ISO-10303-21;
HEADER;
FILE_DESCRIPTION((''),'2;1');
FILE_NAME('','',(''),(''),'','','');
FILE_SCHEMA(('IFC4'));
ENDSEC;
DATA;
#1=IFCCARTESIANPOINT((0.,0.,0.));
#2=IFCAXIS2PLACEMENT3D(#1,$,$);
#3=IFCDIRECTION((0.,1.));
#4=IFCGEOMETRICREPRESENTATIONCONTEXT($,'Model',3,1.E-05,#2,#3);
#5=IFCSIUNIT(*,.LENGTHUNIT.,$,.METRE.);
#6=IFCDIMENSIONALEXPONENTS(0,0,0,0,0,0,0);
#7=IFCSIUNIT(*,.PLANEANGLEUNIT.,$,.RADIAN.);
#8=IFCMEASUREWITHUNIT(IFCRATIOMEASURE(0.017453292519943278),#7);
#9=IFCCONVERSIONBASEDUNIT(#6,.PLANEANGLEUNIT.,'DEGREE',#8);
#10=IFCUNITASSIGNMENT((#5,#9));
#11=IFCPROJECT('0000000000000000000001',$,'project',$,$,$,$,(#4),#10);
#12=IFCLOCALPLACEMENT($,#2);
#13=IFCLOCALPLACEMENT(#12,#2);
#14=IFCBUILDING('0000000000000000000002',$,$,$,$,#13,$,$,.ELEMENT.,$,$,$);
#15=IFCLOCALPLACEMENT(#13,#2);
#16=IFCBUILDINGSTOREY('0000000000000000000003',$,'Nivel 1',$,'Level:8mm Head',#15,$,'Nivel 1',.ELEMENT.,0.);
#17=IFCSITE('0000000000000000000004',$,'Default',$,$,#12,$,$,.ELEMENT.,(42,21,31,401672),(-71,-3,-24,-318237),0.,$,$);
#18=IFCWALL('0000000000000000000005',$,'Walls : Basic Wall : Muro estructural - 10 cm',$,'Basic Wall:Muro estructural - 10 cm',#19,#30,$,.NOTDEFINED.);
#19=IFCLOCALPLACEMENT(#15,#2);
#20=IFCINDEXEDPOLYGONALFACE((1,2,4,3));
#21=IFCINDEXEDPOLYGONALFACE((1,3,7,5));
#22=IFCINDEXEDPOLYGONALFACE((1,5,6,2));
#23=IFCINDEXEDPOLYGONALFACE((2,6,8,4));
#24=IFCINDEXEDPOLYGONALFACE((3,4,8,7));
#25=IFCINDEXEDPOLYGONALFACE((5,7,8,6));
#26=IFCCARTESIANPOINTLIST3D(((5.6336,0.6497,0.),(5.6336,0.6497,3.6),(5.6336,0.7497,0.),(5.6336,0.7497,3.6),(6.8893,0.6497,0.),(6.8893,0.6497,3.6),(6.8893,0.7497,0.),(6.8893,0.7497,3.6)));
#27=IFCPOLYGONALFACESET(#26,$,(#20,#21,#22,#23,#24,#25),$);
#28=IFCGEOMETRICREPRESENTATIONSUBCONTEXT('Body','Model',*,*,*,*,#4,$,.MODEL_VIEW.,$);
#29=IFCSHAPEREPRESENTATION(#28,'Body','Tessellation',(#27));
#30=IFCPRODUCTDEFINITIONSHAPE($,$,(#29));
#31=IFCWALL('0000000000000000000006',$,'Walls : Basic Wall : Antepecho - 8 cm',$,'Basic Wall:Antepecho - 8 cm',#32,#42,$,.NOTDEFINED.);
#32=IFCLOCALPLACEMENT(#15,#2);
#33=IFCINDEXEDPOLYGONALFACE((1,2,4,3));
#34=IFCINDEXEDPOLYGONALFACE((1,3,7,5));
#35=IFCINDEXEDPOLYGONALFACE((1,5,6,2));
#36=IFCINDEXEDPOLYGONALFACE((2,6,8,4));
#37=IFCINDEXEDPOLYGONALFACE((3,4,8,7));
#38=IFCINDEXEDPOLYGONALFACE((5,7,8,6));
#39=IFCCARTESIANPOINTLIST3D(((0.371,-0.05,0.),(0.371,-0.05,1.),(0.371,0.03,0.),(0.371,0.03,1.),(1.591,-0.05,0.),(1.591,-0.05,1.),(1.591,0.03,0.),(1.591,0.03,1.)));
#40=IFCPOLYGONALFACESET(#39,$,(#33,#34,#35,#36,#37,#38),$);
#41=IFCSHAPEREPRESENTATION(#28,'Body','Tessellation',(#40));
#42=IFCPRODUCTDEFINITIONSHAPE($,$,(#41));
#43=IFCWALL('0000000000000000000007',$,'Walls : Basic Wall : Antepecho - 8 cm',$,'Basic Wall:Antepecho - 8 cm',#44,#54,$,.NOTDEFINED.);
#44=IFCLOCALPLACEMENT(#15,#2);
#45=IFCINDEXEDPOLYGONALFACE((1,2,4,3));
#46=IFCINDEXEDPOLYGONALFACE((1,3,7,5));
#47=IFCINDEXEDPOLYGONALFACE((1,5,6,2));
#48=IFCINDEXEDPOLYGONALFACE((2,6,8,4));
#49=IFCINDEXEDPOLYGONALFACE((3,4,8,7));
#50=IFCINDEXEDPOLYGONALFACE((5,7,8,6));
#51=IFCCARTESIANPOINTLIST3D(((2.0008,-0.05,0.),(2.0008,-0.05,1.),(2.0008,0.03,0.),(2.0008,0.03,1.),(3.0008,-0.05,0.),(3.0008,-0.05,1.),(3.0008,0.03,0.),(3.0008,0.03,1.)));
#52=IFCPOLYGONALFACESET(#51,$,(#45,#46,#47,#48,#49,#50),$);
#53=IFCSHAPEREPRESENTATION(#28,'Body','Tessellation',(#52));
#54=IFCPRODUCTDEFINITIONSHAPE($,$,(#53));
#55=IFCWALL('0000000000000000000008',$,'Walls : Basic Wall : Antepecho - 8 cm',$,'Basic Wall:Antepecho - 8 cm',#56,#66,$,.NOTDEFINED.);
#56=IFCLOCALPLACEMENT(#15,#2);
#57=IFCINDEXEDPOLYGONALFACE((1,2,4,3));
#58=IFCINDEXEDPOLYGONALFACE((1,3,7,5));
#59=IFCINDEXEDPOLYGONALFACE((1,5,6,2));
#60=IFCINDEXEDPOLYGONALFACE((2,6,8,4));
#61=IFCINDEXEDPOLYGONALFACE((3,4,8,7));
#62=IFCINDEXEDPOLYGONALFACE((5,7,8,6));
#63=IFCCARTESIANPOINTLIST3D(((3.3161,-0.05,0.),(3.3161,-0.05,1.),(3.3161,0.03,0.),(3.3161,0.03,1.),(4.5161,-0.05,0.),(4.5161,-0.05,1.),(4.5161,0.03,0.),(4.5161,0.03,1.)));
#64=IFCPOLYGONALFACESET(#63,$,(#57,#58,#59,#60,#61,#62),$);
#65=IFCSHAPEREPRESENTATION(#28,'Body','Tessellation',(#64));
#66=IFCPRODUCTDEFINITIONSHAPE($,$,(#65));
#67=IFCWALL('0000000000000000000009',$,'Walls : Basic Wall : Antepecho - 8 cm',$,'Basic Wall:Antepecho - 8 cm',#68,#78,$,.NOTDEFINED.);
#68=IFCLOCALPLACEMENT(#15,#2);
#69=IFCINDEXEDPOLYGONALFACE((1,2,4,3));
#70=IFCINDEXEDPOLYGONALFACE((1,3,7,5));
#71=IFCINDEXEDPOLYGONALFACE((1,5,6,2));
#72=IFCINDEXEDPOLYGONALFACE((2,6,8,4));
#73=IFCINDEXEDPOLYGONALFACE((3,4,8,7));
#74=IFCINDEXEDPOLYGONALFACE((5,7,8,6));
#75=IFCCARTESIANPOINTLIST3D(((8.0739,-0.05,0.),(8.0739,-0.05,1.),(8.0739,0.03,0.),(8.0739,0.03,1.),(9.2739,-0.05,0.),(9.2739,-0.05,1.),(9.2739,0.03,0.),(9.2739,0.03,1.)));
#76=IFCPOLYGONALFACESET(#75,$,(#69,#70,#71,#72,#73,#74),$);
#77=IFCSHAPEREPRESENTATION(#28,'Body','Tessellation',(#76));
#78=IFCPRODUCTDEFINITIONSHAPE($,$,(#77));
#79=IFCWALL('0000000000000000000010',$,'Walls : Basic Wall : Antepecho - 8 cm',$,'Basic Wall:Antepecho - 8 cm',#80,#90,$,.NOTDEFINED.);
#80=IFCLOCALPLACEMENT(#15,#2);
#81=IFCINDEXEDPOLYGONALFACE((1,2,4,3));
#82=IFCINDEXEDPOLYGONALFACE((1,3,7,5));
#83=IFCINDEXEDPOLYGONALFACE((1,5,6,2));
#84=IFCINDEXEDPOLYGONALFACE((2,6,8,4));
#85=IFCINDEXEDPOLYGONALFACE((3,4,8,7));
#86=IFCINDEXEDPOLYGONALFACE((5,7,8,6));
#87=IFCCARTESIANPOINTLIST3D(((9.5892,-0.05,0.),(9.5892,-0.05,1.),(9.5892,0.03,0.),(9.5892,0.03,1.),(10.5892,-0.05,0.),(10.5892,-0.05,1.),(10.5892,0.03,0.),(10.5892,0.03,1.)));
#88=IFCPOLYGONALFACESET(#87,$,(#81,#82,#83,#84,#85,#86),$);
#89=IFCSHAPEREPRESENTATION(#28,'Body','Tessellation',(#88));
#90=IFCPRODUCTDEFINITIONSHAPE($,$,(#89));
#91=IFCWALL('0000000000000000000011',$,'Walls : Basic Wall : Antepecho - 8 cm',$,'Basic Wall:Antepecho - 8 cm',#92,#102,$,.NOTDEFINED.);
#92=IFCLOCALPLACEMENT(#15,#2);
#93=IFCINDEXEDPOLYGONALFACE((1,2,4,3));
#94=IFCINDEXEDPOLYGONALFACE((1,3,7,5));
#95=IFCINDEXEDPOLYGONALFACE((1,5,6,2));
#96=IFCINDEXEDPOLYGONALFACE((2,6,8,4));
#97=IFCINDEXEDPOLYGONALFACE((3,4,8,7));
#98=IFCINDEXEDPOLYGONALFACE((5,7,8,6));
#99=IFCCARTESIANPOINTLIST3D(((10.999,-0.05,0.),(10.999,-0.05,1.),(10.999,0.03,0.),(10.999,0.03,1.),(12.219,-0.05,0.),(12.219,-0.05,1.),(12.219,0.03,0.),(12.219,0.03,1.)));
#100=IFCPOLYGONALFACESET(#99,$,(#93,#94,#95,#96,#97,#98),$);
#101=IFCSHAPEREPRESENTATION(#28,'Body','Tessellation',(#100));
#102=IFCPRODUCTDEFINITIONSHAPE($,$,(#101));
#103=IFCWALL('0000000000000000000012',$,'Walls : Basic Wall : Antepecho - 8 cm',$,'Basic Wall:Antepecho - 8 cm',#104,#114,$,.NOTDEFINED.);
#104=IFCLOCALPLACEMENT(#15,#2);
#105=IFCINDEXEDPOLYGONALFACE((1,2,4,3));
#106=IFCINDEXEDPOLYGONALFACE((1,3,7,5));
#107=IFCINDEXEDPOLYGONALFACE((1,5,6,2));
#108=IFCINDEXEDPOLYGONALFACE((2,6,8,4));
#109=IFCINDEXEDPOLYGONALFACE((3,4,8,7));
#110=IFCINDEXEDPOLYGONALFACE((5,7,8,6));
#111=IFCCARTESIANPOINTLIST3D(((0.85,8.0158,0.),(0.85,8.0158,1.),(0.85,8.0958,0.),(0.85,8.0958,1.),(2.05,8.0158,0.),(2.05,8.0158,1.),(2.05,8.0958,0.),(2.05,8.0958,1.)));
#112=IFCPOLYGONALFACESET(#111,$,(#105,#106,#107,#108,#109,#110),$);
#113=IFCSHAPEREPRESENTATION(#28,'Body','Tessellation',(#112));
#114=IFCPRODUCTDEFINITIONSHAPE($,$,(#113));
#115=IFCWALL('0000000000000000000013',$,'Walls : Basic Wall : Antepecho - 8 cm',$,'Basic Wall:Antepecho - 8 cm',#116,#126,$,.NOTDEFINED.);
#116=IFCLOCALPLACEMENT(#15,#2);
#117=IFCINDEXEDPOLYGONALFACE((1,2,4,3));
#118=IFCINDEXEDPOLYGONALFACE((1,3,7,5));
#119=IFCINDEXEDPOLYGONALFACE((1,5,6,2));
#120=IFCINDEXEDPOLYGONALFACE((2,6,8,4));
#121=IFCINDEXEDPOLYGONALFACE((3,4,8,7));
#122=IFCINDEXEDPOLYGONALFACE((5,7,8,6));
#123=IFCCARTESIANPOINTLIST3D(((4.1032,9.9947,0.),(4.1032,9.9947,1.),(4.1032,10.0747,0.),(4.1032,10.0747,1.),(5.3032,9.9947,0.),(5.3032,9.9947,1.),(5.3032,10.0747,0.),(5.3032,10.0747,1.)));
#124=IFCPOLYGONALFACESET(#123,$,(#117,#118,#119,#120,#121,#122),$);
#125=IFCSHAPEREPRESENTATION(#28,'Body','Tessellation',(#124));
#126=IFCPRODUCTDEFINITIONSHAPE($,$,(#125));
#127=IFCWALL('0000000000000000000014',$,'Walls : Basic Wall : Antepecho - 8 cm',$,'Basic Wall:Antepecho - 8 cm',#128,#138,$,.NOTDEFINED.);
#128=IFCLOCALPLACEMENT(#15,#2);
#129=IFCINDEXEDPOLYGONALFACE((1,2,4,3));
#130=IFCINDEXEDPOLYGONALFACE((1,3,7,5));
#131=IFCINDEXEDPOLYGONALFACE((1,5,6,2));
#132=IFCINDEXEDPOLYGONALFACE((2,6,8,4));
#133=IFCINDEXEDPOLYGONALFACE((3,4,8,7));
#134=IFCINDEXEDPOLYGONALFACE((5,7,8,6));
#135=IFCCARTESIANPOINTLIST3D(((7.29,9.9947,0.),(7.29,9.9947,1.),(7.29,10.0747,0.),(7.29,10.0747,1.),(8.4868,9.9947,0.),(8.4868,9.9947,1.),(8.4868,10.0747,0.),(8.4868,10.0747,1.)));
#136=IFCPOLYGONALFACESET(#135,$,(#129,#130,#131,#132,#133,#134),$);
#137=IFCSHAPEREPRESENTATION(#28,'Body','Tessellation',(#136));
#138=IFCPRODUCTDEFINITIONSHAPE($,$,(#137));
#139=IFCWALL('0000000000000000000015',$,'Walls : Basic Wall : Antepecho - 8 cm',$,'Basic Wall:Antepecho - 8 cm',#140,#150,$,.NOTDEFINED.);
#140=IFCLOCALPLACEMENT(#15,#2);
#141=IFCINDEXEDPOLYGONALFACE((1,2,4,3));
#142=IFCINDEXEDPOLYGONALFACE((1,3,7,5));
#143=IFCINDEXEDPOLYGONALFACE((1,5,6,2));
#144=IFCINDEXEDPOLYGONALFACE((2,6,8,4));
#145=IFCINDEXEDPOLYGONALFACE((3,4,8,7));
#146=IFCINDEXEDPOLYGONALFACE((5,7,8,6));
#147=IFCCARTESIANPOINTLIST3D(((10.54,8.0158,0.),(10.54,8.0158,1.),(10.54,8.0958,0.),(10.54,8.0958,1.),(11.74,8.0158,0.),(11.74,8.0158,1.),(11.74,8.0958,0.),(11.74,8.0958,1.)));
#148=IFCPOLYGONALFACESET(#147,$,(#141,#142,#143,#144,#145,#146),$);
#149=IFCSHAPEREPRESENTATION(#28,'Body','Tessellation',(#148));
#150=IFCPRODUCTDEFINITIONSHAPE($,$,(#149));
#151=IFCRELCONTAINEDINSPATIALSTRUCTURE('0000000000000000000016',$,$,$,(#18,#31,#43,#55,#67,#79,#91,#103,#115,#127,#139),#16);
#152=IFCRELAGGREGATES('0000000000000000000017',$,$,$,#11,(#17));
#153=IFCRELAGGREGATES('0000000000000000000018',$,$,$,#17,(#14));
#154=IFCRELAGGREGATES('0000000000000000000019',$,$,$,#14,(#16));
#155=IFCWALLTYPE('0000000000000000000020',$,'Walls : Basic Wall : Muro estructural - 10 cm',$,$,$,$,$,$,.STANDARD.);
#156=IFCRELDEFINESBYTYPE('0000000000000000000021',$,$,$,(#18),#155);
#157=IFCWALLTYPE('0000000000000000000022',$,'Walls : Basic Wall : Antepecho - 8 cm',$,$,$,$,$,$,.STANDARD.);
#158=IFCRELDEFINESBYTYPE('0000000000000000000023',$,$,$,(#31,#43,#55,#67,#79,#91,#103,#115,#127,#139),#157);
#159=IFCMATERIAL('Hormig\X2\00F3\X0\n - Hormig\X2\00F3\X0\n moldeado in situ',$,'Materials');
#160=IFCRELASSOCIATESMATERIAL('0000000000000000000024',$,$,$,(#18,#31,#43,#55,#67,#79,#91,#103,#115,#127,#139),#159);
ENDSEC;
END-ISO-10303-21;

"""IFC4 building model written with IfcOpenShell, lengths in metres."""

from ifc_helpers import new_model, entity, si_unit, converted_unit, direction, frame, origin, place, context, subcontext, project, spatial, indexed_curve, outline, extrude, material, type_object, element, save


model = new_model("IFC4")

# Units and contexts
model_context = context("Model", 3, precision=1e-05, world=origin(), true_north=direction((0.0, 1.0)))
body_context = subcontext(model_context, "Body", "Model", "MODEL_VIEW")
ifc_project = project(units=[si_unit("LENGTHUNIT", "METRE"), converted_unit("PLANEANGLEUNIT", "DEGREE", entity("IfcRatioMeasure", 0.017453292519943278), si_unit("PLANEANGLEUNIT", "RADIAN"), dimensions=[0, 0, 0, 0, 0, 0, 0])], contexts=[model_context])

# Site, building, storey
site_placement = place(None, origin())
site = spatial("IfcSite", under=ifc_project, at=site_placement, Name="Default", CompositionType="ELEMENT", RefLatitude=(42, 21, 31, 401672), RefLongitude=(-71, -3, -24, -318237), RefElevation=0.0)
building_placement = place(site_placement, origin())
building = spatial("IfcBuilding", under=site, at=building_placement, CompositionType="ELEMENT")
storey_placement = place(building_placement, origin())
storey = spatial("IfcBuildingStorey", under=building, at=storey_placement, Name="Nivel 1", ObjectType="Level:8mm Head", LongName="Nivel 1", CompositionType="ELEMENT", Elevation=0.0)

# Walls
ifc_material_1 = material(Name="Hormigón - Hormigón moldeado in situ", Category="Materials")
wall_type_1 = type_object("IfcWallType", Name="Walls : Basic Wall : Muro estructural - 10 cm", PredefinedType="STANDARD")
wall_1_placement = place(storey_placement, frame((5.6336, 0.6997, 0.0)))
element("IfcWall", 1, at=wall_1_placement, inside=storey, type_object=wall_type_1, material=ifc_material_1, Name="Walls : Basic Wall : Muro estructural - 10 cm", ObjectType="Basic Wall:Muro estructural - 10 cm", PredefinedType="NOTDEFINED", context=body_context, shape_type="SweptSolid", body=[
    extrude(outline(indexed_curve([(1.2557, 0.05), (0.0, 0.05), (0.0, -0.05), (1.2557, -0.05), (1.2557, 0.05)], self_intersect=False)), origin(), (0.0, 0.0, 1.0), 3.6),
])
wall_type_2 = type_object("IfcWallType", Name="Walls : Basic Wall : Antepecho - 8 cm", PredefinedType="STANDARD")
wall_2_placement = place(storey_placement, frame((0.371, -0.01, 0.0)))
element("IfcWall", 2, at=wall_2_placement, inside=storey, type_object=wall_type_2, material=ifc_material_1, Name="Walls : Basic Wall : Antepecho - 8 cm", ObjectType="Basic Wall:Antepecho - 8 cm", PredefinedType="NOTDEFINED", context=body_context, shape_type="SweptSolid", body=[
    extrude(outline(indexed_curve([(1.22, 0.04), (0.0, 0.04), (0.0, -0.04), (1.22, -0.04), (1.22, 0.04)], self_intersect=False)), origin(), (0.0, 0.0, 1.0), 1.0),
])
wall_3_placement = place(storey_placement, frame((2.0008, -0.01, 0.0)))
element("IfcWall", 3, at=wall_3_placement, inside=storey, type_object=wall_type_2, material=ifc_material_1, Name="Walls : Basic Wall : Antepecho - 8 cm", ObjectType="Basic Wall:Antepecho - 8 cm", PredefinedType="NOTDEFINED", context=body_context, shape_type="SweptSolid", body=[
    extrude(outline(indexed_curve([(1.0, 0.04), (0.0, 0.04), (0.0, -0.04), (1.0, -0.04), (1.0, 0.04)], self_intersect=False)), origin(), (0.0, 0.0, 1.0), 1.0),
])
wall_4_placement = place(storey_placement, frame((3.3161, -0.01, 0.0)))
element("IfcWall", 4, at=wall_4_placement, inside=storey, type_object=wall_type_2, material=ifc_material_1, Name="Walls : Basic Wall : Antepecho - 8 cm", ObjectType="Basic Wall:Antepecho - 8 cm", PredefinedType="NOTDEFINED", context=body_context, shape_type="SweptSolid", body=[
    extrude(outline(indexed_curve([(1.2, 0.04), (0.0, 0.04), (0.0, -0.04), (1.2, -0.04), (1.2, 0.04)], self_intersect=False)), origin(), (0.0, 0.0, 1.0), 1.0),
])
wall_5_placement = place(storey_placement, frame((8.0739, -0.01, 0.0)))
element("IfcWall", 5, at=wall_5_placement, inside=storey, type_object=wall_type_2, material=ifc_material_1, Name="Walls : Basic Wall : Antepecho - 8 cm", ObjectType="Basic Wall:Antepecho - 8 cm", PredefinedType="NOTDEFINED", context=body_context, shape_type="SweptSolid", body=[
    extrude(outline(indexed_curve([(1.2, 0.04), (0.0, 0.04), (0.0, -0.04), (1.2, -0.04), (1.2, 0.04)], self_intersect=False)), origin(), (0.0, 0.0, 1.0), 1.0),
])
wall_6_placement = place(storey_placement, frame((9.5892, -0.01, 0.0)))
element("IfcWall", 6, at=wall_6_placement, inside=storey, type_object=wall_type_2, material=ifc_material_1, Name="Walls : Basic Wall : Antepecho - 8 cm", ObjectType="Basic Wall:Antepecho - 8 cm", PredefinedType="NOTDEFINED", context=body_context, shape_type="SweptSolid", body=[
    extrude(outline(indexed_curve([(1.0, 0.04), (0.0, 0.04), (0.0, -0.04), (1.0, -0.04), (1.0, 0.04)], self_intersect=False)), origin(), (0.0, 0.0, 1.0), 1.0),
])
wall_7_placement = place(storey_placement, frame((10.999, -0.01, 0.0)))
element("IfcWall", 7, at=wall_7_placement, inside=storey, type_object=wall_type_2, material=ifc_material_1, Name="Walls : Basic Wall : Antepecho - 8 cm", ObjectType="Basic Wall:Antepecho - 8 cm", PredefinedType="NOTDEFINED", context=body_context, shape_type="SweptSolid", body=[
    extrude(outline(indexed_curve([(1.22, 0.04), (0.0, 0.04), (0.0, -0.04), (1.22, -0.04), (1.22, 0.04)], self_intersect=False)), origin(), (0.0, 0.0, 1.0), 1.0),
])
wall_8_placement = place(storey_placement, frame((2.05, 8.0558, 0.0), z_axis=(0.0, 0.0, 1.0), x_axis=(-1.0, 0.0, 0.0)))
element("IfcWall", 8, at=wall_8_placement, inside=storey, type_object=wall_type_2, material=ifc_material_1, Name="Walls : Basic Wall : Antepecho - 8 cm", ObjectType="Basic Wall:Antepecho - 8 cm", PredefinedType="NOTDEFINED", context=body_context, shape_type="SweptSolid", body=[
    extrude(outline(indexed_curve([(1.2, 0.04), (0.0, 0.04), (0.0, -0.04), (1.2, -0.04), (1.2, 0.04)], self_intersect=False)), origin(), (0.0, 0.0, 1.0), 1.0),
])
wall_9_placement = place(storey_placement, frame((5.3032, 10.0347, 0.0), z_axis=(0.0, 0.0, 1.0), x_axis=(-1.0, 0.0, 0.0)))
element("IfcWall", 9, at=wall_9_placement, inside=storey, type_object=wall_type_2, material=ifc_material_1, Name="Walls : Basic Wall : Antepecho - 8 cm", ObjectType="Basic Wall:Antepecho - 8 cm", PredefinedType="NOTDEFINED", context=body_context, shape_type="SweptSolid", body=[
    extrude(outline(indexed_curve([(1.2, 0.04), (0.0, 0.04), (0.0, -0.04), (1.2, -0.04), (1.2, 0.04)], self_intersect=False)), origin(), (0.0, 0.0, 1.0), 1.0),
])
wall_10_placement = place(storey_placement, frame((8.4868, 10.0347, 0.0), z_axis=(0.0, 0.0, 1.0), x_axis=(-1.0, 0.0, 0.0)))
element("IfcWall", 10, at=wall_10_placement, inside=storey, type_object=wall_type_2, material=ifc_material_1, Name="Walls : Basic Wall : Antepecho - 8 cm", ObjectType="Basic Wall:Antepecho - 8 cm", PredefinedType="NOTDEFINED", context=body_context, shape_type="SweptSolid", body=[
    extrude(outline(indexed_curve([(1.1968, 0.04), (0.0, 0.04), (0.0, -0.04), (1.1968, -0.04), (1.1968, 0.04)], self_intersect=False)), origin(), (0.0, 0.0, 1.0), 1.0),
])
wall_11_placement = place(storey_placement, frame((11.74, 8.0558, 0.0), z_axis=(0.0, 0.0, 1.0), x_axis=(-1.0, 0.0, 0.0)))
element("IfcWall", 11, at=wall_11_placement, inside=storey, type_object=wall_type_2, material=ifc_material_1, Name="Walls : Basic Wall : Antepecho - 8 cm", ObjectType="Basic Wall:Antepecho - 8 cm", PredefinedType="NOTDEFINED", context=body_context, shape_type="SweptSolid", body=[
    extrude(outline(indexed_curve([(1.2, 0.04), (0.0, 0.04), (0.0, -0.04), (1.2, -0.04), (1.2, 0.04)], self_intersect=False)), origin(), (0.0, 0.0, 1.0), 1.0),
])

save(model, "model.ifc")
